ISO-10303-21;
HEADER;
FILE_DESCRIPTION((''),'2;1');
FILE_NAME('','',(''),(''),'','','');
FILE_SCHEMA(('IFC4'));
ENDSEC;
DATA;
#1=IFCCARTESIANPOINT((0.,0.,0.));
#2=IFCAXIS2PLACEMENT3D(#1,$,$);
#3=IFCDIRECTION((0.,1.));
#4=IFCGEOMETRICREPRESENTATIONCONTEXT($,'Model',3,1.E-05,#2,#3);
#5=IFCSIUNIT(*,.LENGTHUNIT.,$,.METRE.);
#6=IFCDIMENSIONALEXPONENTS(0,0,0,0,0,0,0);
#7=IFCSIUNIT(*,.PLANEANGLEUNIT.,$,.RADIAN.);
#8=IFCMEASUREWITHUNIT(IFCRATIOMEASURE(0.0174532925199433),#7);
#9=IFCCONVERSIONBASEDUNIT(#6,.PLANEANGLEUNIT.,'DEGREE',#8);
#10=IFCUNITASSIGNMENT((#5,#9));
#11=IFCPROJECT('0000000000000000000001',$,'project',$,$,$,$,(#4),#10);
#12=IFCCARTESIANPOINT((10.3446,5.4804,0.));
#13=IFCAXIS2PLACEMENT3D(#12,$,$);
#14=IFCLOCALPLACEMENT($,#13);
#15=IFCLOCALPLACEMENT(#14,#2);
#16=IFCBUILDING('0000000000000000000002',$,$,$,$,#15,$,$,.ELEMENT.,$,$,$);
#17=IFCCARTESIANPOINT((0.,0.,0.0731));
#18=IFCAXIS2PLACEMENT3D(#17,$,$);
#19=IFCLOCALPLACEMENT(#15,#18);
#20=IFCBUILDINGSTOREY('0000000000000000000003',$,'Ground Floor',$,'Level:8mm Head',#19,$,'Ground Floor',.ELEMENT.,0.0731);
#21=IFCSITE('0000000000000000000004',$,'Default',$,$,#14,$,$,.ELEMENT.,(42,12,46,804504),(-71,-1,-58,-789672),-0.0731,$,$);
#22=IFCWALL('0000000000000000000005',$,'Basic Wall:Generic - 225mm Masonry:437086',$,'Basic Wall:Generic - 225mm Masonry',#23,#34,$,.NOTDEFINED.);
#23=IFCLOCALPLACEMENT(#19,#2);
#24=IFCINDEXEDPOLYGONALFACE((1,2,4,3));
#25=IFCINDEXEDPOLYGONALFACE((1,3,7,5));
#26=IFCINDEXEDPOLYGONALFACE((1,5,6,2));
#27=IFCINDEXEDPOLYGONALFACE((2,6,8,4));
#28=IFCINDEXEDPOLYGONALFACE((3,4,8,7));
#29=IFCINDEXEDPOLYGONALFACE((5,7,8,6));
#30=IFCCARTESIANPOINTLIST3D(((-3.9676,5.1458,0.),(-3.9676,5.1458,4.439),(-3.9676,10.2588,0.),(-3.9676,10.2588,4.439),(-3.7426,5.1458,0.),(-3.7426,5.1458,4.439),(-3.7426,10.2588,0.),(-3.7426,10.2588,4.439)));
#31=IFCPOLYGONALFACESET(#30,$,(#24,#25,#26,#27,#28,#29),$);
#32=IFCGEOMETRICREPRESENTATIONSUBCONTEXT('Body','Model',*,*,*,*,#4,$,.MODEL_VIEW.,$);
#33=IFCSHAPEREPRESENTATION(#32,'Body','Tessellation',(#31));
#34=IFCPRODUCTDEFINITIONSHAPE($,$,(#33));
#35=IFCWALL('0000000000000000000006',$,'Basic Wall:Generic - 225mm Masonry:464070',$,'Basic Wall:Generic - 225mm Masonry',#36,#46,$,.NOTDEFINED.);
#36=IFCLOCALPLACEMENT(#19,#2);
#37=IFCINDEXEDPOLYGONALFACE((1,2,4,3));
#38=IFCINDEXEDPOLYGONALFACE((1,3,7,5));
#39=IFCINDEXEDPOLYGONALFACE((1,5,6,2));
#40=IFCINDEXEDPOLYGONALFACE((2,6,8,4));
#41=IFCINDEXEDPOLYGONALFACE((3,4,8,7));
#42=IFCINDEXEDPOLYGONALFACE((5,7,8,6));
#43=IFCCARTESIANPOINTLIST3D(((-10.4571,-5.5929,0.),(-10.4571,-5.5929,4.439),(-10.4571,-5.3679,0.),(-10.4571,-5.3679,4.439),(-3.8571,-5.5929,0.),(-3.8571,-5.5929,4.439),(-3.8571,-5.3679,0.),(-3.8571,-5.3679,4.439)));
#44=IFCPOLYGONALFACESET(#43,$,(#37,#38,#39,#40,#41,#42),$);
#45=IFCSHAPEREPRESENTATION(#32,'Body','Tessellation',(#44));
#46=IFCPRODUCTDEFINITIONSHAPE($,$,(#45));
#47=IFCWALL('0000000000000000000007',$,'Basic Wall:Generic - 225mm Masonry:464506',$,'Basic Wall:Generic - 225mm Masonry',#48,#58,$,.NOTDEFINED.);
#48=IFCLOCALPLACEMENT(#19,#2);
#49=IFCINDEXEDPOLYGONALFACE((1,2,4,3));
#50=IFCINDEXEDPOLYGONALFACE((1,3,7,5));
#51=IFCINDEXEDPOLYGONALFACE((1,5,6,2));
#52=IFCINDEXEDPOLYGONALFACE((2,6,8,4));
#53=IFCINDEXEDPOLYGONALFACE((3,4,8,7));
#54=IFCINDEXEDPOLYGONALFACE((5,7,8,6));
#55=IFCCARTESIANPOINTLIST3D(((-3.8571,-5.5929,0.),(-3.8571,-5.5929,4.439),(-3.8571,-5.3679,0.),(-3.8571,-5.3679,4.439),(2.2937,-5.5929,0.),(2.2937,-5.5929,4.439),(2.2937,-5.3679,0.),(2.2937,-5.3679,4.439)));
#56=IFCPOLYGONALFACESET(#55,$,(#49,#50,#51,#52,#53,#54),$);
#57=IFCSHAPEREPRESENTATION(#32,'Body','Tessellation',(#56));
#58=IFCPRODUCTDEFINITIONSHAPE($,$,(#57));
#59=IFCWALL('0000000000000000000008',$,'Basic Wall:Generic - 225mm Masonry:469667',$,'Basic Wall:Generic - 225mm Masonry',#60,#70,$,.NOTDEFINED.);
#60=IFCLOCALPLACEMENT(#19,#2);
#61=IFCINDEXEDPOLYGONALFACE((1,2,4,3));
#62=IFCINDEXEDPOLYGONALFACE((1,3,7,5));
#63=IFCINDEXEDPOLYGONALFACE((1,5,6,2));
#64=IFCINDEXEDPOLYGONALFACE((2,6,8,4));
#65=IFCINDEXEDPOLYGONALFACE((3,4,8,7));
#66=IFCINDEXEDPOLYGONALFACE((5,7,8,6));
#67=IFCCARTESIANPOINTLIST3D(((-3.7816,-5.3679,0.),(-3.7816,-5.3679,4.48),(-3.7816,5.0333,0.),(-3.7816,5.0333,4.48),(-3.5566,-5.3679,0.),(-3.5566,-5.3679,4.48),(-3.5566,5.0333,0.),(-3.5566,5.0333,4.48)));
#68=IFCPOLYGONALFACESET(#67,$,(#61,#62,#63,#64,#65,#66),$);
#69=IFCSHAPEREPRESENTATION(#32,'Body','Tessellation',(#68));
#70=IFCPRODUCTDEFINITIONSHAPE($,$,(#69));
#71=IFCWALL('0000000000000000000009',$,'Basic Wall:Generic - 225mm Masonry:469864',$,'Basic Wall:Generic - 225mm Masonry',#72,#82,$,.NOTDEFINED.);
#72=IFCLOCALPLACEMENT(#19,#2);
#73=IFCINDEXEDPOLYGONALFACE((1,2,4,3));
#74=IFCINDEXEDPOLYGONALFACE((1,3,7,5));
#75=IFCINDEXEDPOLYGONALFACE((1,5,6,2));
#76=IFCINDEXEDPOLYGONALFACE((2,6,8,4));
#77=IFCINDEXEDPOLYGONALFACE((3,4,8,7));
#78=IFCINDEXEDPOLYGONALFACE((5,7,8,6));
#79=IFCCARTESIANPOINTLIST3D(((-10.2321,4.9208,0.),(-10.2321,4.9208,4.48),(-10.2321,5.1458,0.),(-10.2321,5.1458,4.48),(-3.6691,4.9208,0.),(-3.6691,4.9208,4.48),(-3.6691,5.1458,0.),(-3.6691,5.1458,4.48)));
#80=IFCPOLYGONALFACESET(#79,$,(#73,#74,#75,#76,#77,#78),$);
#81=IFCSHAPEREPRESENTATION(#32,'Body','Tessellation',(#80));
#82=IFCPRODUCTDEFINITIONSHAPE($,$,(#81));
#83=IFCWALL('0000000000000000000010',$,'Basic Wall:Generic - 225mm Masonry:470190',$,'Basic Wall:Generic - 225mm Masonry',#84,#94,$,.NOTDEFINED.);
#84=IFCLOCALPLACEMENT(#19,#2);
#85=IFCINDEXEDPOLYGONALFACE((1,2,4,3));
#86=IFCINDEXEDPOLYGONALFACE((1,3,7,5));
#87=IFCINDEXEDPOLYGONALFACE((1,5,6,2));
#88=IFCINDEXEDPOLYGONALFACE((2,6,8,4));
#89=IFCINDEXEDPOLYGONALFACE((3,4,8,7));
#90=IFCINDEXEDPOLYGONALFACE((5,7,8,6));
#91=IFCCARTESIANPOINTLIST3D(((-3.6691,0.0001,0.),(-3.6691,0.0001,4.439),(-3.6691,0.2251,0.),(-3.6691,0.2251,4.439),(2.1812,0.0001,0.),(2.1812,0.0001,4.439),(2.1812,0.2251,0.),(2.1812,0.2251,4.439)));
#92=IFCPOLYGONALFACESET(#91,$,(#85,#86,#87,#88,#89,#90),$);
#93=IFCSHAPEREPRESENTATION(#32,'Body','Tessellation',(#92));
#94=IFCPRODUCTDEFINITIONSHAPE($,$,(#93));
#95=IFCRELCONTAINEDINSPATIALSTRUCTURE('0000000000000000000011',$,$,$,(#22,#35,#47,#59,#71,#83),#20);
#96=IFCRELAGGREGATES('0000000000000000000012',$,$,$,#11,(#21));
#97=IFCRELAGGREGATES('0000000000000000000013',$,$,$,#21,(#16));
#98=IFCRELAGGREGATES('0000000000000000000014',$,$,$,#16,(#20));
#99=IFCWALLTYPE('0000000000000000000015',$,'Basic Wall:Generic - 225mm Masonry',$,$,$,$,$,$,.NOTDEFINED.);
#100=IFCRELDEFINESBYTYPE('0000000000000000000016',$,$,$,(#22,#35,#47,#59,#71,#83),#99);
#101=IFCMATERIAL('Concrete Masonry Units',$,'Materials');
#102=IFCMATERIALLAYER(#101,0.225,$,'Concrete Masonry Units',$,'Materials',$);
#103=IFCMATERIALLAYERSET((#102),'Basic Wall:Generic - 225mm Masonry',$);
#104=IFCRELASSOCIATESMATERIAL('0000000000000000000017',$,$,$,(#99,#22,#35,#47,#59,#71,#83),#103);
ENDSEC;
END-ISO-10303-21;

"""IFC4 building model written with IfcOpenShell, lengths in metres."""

from ifc_helpers import new_model, entity, si_unit, converted_unit, direction, frame, frame_2d, origin, place, context, subcontext, project, spatial, polyline, rectangle, extrude, clip, bounded_halfspace, material, layer, layer_set, layer_usage, type_object, element, save


model = new_model("IFC4")

# Units and contexts
model_context = context("Model", 3, precision=1e-05, world=origin(), true_north=direction((0.0, 1.0)))
body_context = subcontext(model_context, "Body", "Model", "MODEL_VIEW")
ifc_project = project(units=[si_unit("LENGTHUNIT", "METRE"), converted_unit("PLANEANGLEUNIT", "DEGREE", entity("IfcRatioMeasure", 0.0174532925199433), si_unit("PLANEANGLEUNIT", "RADIAN"), dimensions=[0, 0, 0, 0, 0, 0, 0])], contexts=[model_context])

# Site, building, storey
site_placement = place(None, frame((10.3446, 5.4804, 0.0)))
site = spatial("IfcSite", under=ifc_project, at=site_placement, Name="Default", CompositionType="ELEMENT", RefLatitude=(42, 12, 46, 804504), RefLongitude=(-71, -1, -58, -789672), RefElevation=-0.0731)
building_placement = place(site_placement, origin())
building = spatial("IfcBuilding", under=site, at=building_placement, CompositionType="ELEMENT")
storey_placement = place(building_placement, frame((0.0, 0.0, 0.0731)))
storey = spatial("IfcBuildingStorey", under=building, at=storey_placement, Name="Ground Floor", ObjectType="Level:8mm Head", LongName="Ground Floor", CompositionType="ELEMENT", Elevation=0.0731)

# Walls
ifc_material_1 = material(Name="Concrete Masonry Units", Category="Materials")
ifc_layer = layer(ifc_material_1, 0.225, Name="Concrete Masonry Units", Category="Materials")
ifc_layer_set = layer_set([ifc_layer], Name="Basic Wall:Generic - 225mm Masonry")
wall_type = type_object("IfcWallType", Name="Basic Wall:Generic - 225mm Masonry", PredefinedType="NOTDEFINED", material=ifc_layer_set)
ifc_layer_usage_1 = layer_usage(ifc_layer_set, "AXIS2", "NEGATIVE", 0.1125)
wall_1_placement = place(storey_placement, frame((-3.8551, 10.2588, 0.0), z_axis=(0.0, 0.0, 1.0), x_axis=(0.0, -1.0, 0.0)))
element("IfcWall", 1, at=wall_1_placement, inside=storey, type_object=wall_type, material=ifc_layer_usage_1, Name="Basic Wall:Generic - 225mm Masonry:437086", ObjectType="Basic Wall:Generic - 225mm Masonry", PredefinedType="NOTDEFINED", context=body_context, shape_type="Clipping", body=[
    clip(clip(extrude(rectangle(XDim=5.113, YDim=0.225, at=frame_2d((2.5565, 0.0), x_axis=(-1.0, 0.0))), origin(), (0.0, 0.0, 1.0), 4.439), bounded_halfspace(frame((0.0, -0.1125, 4.439), z_axis=(0.0, 0.0, -1.0), x_axis=(1.0, 0.0, 0.0)), True, frame((0.0, -0.1125, 4.439)), polyline([(0.0, 0.0), (5.113, 0.0), (5.113, 0.1125), (0.0, 0.1125), (0.0, 0.0)]))), bounded_halfspace(frame((5.113, 0.0, 4.439), z_axis=(0.0, 0.0, -1.0), x_axis=(1.0, 0.0, 0.0)), True, frame((5.113, 0.0, 4.439)), polyline([(0.0, 0.0), (0.0, 0.1125), (-5.113, 0.1125), (-5.113, 0.0), (0.0, 0.0)]))),
])
ifc_layer_usage_2 = layer_usage(ifc_layer_set, "AXIS2", "NEGATIVE", 0.1125)
wall_2_placement = place(storey_placement, frame((-10.4571, -5.4804, 0.0)))
element("IfcWall", 2, at=wall_2_placement, inside=storey, type_object=wall_type, material=ifc_layer_usage_2, Name="Basic Wall:Generic - 225mm Masonry:464070", ObjectType="Basic Wall:Generic - 225mm Masonry", PredefinedType="NOTDEFINED", context=body_context, shape_type="Clipping", body=[
    clip(extrude(rectangle(XDim=6.6, YDim=0.225, at=frame_2d((3.3, 0.0), x_axis=(-1.0, 0.0))), origin(), (0.0, 0.0, 1.0), 4.439), bounded_halfspace(frame((6.6, 0.0, 4.439), z_axis=(0.0, 0.0, -1.0), x_axis=(0.0, -1.0, 0.0)), True, frame((6.6, 0.0, 4.439)), polyline([(0.0, 0.0), (0.0, 0.1125), (-6.375, 0.1125), (-6.4875, 0.1125), (-6.4875, 0.0), (0.0, 0.0)]))),
])
ifc_layer_usage_3 = layer_usage(ifc_layer_set, "AXIS2", "NEGATIVE", 0.1125)
wall_3_placement = place(storey_placement, frame((-3.8571, -5.4804, 0.0)))
element("IfcWall", 3, at=wall_3_placement, inside=storey, type_object=wall_type, material=ifc_layer_usage_3, Name="Basic Wall:Generic - 225mm Masonry:464506", ObjectType="Basic Wall:Generic - 225mm Masonry", PredefinedType="NOTDEFINED", context=body_context, shape_type="SweptSolid", body=[
    extrude(rectangle(XDim=6.1508, YDim=0.225, at=frame_2d((3.0754, 0.0), x_axis=(-1.0, 0.0))), origin(), (0.0, 0.0, 1.0), 4.439),
])
ifc_layer_usage_4 = layer_usage(ifc_layer_set, "AXIS2", "NEGATIVE", 0.1125)
wall_4_placement = place(storey_placement, frame((-3.6691, -5.3679, 0.0), z_axis=(0.0, 0.0, 1.0), x_axis=(0.0, 1.0, 0.0)))
element("IfcWall", 4, at=wall_4_placement, inside=storey, type_object=wall_type, material=ifc_layer_usage_4, Name="Basic Wall:Generic - 225mm Masonry:469667", ObjectType="Basic Wall:Generic - 225mm Masonry", PredefinedType="NOTDEFINED", context=body_context, shape_type="SweptSolid", body=[
    extrude(rectangle(XDim=10.4013, YDim=0.225, at=frame_2d((5.2006, 0.0), x_axis=(-1.0, 0.0))), origin(), (0.0, 0.0, 1.0), 4.48),
])
ifc_layer_usage_5 = layer_usage(ifc_layer_set, "AXIS2", "NEGATIVE", 0.1125)
wall_5_placement = place(storey_placement, frame((-3.6691, 5.0333, 0.0), z_axis=(0.0, 0.0, 1.0), x_axis=(-1.0, 0.0, 0.0)))
element("IfcWall", 5, at=wall_5_placement, inside=storey, type_object=wall_type, material=ifc_layer_usage_5, Name="Basic Wall:Generic - 225mm Masonry:469864", ObjectType="Basic Wall:Generic - 225mm Masonry", PredefinedType="NOTDEFINED", context=body_context, shape_type="SweptSolid", body=[
    extrude(rectangle(XDim=6.5631, YDim=0.225, at=frame_2d((3.2815, 0.0), x_axis=(-1.0, 0.0))), origin(), (0.0, 0.0, 1.0), 4.48),
])
ifc_layer_usage_6 = layer_usage(ifc_layer_set, "AXIS2", "NEGATIVE", 0.1125)
wall_6_placement = place(storey_placement, frame((-3.6691, 0.1126, 0.0)))
element("IfcWall", 6, at=wall_6_placement, inside=storey, type_object=wall_type, material=ifc_layer_usage_6, Name="Basic Wall:Generic - 225mm Masonry:470190", ObjectType="Basic Wall:Generic - 225mm Masonry", PredefinedType="NOTDEFINED", context=body_context, shape_type="Clipping", body=[
    clip(clip(extrude(rectangle(XDim=5.8502, YDim=0.225, at=frame_2d((2.9251, 0.0), x_axis=(-1.0, 0.0))), origin(), (0.0, 0.0, 1.0), 4.439), bounded_halfspace(frame((5.8502, 0.1013, 4.439), z_axis=(0.0, 0.0, -1.0), x_axis=(0.0, -1.0, 0.0)), True, frame((5.8502, 0.1013, 4.439)), polyline([(0.0, 0.0), (0.0, 0.0112), (-5.8502, 0.0112), (-5.8502, 0.0), (0.0, 0.0)]))), bounded_halfspace(frame((0.0, -0.1125, 4.439), z_axis=(0.0, 0.0, -1.0), x_axis=(-1.0, 0.0, 0.0)), True, frame((0.0, -0.1125, 4.439)), polyline([(0.0, 0.0), (5.8502, 0.0), (5.8502, 0.2138), (0.0, 0.2138), (0.0, 0.0)]))),
])

save(model, "model.ifc")
